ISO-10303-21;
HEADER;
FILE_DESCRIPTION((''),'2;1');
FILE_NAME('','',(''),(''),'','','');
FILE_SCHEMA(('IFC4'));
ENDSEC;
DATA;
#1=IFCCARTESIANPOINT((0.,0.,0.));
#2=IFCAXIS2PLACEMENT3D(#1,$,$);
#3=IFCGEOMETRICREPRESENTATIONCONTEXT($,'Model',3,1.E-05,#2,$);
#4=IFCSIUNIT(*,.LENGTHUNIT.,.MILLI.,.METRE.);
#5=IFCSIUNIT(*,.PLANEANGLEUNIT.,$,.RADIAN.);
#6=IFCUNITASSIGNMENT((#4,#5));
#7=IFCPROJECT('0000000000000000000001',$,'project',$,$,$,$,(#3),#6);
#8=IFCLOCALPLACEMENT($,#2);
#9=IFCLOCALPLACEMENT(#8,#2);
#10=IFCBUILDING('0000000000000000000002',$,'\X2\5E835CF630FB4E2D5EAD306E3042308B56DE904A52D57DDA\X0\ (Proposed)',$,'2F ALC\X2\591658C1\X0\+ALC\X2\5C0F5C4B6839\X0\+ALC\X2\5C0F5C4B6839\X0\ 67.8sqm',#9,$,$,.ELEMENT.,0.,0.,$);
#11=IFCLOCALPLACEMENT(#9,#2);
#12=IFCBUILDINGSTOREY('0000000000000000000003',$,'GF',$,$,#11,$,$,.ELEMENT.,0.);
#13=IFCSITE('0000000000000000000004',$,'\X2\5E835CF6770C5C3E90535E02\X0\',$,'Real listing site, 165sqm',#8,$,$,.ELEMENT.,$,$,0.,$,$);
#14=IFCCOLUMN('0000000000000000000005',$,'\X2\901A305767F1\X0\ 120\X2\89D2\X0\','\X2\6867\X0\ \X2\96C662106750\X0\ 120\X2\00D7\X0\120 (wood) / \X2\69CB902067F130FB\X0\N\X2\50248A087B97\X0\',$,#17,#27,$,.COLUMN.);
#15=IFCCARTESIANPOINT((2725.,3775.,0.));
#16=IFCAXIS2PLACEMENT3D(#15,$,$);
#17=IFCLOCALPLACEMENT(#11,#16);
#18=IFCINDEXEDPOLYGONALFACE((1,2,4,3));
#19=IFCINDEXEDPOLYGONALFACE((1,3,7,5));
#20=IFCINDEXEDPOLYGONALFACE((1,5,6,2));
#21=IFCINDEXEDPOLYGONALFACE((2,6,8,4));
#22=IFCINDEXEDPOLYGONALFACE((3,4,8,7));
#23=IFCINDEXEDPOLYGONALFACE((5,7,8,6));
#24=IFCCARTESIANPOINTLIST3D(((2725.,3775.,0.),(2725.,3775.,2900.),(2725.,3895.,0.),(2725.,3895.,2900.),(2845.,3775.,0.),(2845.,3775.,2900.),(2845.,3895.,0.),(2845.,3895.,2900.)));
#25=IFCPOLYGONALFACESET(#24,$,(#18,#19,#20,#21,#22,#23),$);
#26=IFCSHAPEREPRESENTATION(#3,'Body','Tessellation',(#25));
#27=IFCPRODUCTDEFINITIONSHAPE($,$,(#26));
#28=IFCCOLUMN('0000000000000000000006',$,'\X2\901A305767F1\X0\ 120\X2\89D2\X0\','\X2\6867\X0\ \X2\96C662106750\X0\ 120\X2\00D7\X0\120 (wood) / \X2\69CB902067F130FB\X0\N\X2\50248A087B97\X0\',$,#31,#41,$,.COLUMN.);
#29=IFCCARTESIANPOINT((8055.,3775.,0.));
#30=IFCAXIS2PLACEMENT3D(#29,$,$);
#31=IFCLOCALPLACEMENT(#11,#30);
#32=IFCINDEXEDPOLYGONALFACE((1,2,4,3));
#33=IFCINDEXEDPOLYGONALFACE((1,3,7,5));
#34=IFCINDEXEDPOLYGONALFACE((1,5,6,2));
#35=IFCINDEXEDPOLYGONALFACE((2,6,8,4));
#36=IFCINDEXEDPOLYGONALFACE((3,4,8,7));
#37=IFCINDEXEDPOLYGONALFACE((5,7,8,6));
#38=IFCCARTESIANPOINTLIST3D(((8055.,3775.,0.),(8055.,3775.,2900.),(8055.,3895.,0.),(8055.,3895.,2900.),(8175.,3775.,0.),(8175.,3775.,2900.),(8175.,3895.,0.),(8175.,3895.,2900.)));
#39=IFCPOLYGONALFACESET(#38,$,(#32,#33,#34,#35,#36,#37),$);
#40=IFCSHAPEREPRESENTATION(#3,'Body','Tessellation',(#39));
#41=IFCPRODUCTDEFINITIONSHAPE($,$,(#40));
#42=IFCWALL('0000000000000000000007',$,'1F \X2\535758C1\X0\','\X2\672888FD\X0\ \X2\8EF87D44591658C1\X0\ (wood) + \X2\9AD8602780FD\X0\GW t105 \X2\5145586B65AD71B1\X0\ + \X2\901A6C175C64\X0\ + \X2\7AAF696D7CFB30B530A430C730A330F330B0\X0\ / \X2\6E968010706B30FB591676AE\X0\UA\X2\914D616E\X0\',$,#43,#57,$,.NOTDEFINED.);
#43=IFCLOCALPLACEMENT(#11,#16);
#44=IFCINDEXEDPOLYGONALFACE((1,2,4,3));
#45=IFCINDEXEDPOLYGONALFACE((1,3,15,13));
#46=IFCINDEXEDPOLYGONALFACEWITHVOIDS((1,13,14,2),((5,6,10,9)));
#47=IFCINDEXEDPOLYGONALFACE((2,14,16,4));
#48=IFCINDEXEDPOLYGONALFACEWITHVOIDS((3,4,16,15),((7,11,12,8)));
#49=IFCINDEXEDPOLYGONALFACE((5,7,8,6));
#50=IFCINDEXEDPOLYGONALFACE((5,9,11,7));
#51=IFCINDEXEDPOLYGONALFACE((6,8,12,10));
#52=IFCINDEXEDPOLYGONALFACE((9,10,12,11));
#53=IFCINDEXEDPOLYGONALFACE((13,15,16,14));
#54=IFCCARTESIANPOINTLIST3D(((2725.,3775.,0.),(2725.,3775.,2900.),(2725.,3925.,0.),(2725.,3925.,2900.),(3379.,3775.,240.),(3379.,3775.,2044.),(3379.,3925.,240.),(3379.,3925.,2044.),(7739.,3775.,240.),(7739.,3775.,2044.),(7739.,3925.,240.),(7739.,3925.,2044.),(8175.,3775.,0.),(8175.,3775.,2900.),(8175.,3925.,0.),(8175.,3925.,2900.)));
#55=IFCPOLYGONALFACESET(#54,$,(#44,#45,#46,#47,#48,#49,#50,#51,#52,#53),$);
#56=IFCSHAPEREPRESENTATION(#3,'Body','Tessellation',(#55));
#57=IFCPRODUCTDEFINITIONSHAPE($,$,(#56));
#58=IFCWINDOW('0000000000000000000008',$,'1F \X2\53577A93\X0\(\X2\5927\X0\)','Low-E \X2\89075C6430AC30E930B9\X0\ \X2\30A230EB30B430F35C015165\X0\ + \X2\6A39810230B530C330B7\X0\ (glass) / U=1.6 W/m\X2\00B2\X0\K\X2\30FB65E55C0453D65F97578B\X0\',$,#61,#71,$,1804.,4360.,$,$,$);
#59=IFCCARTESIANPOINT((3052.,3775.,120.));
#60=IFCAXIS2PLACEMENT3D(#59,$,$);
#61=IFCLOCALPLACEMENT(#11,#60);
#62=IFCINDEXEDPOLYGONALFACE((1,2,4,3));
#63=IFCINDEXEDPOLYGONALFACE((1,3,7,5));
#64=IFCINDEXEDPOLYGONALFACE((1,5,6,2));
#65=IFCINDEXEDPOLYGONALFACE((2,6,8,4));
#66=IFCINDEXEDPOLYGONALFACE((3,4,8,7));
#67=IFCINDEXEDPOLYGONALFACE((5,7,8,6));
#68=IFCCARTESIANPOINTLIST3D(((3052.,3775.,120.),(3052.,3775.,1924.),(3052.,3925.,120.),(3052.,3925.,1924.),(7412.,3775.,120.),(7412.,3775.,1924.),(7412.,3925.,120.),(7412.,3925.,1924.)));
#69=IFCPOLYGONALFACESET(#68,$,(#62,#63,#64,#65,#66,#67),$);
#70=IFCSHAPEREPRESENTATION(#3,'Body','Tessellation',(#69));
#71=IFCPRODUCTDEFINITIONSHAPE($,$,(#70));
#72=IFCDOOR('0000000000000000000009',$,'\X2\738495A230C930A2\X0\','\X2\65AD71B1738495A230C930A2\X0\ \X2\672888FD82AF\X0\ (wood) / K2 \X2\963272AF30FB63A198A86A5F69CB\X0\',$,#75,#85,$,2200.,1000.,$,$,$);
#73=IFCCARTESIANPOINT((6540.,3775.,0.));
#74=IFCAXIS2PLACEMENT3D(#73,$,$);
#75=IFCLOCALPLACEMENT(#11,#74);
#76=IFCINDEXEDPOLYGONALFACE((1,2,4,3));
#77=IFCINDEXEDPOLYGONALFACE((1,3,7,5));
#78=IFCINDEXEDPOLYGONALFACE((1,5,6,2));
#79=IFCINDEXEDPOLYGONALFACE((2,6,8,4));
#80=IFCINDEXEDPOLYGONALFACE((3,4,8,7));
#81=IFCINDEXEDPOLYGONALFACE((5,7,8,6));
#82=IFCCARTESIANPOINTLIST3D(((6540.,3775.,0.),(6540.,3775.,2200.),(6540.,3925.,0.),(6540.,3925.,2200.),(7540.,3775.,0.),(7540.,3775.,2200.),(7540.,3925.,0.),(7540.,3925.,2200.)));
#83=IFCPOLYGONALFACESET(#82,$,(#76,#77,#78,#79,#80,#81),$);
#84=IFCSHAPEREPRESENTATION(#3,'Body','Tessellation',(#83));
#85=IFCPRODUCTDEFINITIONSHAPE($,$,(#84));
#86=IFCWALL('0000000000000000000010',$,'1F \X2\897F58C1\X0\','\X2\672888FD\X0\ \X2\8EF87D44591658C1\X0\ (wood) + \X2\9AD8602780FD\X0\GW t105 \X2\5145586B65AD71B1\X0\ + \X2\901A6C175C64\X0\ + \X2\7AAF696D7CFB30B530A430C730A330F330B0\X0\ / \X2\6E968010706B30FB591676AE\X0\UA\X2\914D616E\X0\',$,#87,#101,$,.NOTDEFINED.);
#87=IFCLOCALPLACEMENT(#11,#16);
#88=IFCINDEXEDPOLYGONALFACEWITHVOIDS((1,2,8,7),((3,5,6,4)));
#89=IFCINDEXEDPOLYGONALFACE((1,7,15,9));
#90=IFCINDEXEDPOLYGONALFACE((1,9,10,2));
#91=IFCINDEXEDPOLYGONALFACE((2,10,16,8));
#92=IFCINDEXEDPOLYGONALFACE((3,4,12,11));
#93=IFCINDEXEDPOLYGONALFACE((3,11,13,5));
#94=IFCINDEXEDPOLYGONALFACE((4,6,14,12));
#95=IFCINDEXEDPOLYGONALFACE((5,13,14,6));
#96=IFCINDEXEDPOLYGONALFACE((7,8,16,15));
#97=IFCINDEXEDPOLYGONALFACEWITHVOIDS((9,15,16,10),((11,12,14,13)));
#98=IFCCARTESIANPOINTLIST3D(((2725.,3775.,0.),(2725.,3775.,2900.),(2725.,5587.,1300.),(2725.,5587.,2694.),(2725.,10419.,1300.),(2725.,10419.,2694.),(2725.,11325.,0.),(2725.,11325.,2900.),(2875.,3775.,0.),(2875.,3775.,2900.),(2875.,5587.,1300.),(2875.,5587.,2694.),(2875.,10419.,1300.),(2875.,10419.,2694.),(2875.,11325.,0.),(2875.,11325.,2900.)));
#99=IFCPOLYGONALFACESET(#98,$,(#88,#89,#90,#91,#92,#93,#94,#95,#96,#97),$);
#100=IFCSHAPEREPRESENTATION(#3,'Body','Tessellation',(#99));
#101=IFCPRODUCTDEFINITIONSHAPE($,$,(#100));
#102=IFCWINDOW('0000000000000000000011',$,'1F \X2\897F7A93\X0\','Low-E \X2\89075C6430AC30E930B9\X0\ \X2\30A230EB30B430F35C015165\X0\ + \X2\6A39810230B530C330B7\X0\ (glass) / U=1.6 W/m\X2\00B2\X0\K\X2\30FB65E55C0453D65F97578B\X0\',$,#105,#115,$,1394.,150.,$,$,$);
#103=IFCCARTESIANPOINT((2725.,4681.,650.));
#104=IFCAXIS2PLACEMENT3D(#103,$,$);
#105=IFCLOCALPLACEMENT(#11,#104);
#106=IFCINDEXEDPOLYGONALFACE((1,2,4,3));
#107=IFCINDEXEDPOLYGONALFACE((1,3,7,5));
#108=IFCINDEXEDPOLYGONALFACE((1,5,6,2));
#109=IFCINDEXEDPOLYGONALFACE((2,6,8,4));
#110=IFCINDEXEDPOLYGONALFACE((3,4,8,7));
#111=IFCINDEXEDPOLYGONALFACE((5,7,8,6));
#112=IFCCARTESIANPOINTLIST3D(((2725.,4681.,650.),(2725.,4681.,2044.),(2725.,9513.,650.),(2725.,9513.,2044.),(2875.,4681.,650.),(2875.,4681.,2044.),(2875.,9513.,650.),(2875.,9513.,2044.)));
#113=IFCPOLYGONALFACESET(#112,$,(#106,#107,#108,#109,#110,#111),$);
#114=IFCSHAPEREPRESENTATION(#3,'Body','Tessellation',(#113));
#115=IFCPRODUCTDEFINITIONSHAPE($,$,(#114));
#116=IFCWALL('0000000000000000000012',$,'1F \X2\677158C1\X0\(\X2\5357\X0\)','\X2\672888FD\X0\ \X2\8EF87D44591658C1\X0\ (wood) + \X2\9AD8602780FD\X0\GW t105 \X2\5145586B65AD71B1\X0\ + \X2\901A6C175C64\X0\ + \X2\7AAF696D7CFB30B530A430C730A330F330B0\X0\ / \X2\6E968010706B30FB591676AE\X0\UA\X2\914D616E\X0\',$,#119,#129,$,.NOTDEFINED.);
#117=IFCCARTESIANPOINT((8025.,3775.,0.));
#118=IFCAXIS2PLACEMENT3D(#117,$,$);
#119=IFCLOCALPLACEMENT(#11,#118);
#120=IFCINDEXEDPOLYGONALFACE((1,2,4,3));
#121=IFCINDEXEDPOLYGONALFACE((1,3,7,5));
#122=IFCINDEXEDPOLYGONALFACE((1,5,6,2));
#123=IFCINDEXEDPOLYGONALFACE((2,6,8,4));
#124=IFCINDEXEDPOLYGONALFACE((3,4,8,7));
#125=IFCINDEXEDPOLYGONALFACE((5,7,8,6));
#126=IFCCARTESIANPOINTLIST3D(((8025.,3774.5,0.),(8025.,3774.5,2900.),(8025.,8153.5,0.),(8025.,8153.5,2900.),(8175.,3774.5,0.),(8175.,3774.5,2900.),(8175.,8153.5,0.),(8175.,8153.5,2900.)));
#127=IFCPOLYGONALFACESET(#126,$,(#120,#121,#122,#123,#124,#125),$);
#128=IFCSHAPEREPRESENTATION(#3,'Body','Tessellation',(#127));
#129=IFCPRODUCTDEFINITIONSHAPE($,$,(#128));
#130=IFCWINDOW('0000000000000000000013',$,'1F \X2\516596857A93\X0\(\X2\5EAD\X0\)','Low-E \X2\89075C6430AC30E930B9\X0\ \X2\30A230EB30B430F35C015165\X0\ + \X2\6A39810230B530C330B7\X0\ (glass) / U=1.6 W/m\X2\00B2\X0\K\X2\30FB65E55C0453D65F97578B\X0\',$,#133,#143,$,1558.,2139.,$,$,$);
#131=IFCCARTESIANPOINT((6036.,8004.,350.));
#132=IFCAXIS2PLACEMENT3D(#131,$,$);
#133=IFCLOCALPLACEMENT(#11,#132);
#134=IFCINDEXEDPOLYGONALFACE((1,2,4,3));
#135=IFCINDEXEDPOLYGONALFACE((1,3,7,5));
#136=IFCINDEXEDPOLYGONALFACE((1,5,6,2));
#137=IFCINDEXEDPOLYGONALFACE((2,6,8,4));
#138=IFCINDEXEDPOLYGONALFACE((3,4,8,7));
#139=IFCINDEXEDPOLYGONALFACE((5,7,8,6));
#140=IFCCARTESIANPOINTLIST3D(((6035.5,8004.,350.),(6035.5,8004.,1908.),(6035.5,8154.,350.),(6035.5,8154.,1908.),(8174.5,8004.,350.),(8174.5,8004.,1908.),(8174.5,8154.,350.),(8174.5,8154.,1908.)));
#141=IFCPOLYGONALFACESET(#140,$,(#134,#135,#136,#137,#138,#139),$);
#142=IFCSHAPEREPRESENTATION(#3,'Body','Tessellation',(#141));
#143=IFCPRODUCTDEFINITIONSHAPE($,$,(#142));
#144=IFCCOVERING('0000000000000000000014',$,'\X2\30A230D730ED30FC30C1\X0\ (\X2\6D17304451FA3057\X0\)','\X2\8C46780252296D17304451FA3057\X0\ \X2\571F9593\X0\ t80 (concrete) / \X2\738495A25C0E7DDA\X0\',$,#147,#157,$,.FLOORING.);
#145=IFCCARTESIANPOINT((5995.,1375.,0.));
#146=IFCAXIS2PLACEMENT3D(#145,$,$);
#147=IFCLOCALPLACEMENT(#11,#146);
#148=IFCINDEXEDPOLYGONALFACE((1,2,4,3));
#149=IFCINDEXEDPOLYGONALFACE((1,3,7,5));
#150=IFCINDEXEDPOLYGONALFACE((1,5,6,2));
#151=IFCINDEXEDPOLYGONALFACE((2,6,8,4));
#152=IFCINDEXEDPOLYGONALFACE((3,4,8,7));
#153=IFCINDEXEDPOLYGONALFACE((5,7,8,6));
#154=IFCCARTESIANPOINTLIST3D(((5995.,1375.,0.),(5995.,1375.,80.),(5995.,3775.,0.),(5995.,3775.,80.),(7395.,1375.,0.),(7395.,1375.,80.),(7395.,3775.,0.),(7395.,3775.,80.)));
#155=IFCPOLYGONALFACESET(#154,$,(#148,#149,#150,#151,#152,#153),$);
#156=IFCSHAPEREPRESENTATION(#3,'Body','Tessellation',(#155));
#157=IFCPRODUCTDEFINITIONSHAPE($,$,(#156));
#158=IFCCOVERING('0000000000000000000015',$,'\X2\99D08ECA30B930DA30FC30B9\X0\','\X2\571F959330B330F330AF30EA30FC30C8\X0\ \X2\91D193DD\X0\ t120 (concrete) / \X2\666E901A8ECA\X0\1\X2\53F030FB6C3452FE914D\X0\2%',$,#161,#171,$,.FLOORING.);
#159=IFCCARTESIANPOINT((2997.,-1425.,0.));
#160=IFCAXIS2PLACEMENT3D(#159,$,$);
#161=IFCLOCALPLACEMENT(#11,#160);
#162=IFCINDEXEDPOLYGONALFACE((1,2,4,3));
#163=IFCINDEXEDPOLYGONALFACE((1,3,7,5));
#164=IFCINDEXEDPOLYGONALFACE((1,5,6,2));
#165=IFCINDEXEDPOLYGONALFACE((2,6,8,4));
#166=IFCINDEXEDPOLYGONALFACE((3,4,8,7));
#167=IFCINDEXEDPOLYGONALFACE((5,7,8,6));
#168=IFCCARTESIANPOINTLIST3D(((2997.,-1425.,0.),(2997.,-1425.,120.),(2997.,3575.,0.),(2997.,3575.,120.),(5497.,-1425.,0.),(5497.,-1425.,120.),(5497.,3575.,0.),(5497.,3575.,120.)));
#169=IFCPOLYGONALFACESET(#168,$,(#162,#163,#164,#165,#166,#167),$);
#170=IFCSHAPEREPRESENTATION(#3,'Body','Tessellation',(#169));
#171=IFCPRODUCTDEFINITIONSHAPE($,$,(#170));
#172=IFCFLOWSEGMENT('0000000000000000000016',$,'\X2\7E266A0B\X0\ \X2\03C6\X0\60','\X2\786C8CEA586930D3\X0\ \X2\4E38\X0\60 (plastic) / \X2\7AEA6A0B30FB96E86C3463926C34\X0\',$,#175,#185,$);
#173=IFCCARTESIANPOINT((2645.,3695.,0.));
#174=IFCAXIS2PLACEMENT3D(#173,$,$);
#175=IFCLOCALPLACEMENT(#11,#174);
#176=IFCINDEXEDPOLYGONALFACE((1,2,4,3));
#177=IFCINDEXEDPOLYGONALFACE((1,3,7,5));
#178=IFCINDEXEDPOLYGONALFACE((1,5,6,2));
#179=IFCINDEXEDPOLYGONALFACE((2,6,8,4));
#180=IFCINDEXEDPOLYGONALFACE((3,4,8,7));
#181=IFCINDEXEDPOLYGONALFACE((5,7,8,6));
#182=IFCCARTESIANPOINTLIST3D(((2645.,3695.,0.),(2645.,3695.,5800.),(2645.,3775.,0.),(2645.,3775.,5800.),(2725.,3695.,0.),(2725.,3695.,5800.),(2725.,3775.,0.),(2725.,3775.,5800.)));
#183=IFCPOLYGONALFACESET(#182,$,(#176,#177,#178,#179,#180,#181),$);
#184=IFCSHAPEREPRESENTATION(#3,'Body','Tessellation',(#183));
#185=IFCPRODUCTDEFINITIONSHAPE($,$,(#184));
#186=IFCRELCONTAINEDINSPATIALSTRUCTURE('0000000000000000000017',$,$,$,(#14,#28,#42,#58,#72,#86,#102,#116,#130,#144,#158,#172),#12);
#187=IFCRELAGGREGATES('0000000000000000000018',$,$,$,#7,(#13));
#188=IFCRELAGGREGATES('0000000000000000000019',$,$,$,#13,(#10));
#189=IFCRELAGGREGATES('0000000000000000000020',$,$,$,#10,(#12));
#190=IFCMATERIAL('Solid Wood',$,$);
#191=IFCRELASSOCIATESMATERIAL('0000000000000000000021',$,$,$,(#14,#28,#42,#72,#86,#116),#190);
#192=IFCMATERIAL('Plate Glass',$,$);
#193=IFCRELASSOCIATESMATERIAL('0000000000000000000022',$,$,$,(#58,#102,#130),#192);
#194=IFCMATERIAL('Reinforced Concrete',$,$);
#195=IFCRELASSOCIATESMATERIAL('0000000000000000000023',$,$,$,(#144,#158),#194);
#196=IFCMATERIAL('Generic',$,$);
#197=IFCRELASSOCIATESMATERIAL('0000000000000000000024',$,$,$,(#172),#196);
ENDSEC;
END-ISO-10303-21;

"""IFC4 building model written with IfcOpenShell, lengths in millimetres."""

from ifc_helpers import new_model, si_unit, frame, frame_2d, origin, place, context, project, spatial, rectangle, extrude, material, element, fill, save


model = new_model("IFC4")

# Units and contexts
model_context = context("Model", 3, precision=1e-05, world=origin())
ifc_project = project(units=[si_unit("LENGTHUNIT", "METRE", prefix="MILLI"), si_unit("PLANEANGLEUNIT", "RADIAN")], contexts=[model_context])

# Site, building, storey
site_placement = place(None, origin())
site = spatial("IfcSite", under=ifc_project, at=site_placement, Name="広島県尾道市", ObjectType="Real listing site, 165sqm", CompositionType="ELEMENT", RefElevation=0.0)
building_placement = place(site_placement, origin())
building = spatial("IfcBuilding", under=site, at=building_placement, Name="広島・中庭のある回遊動線 (Proposed)", ObjectType="2F ALC外壁+ALC小屋根+ALC小屋根 67.8sqm", CompositionType="ELEMENT", ElevationOfRefHeight=0.0, ElevationOfTerrain=0.0)
storey_placement = place(building_placement, origin())
storey = spatial("IfcBuildingStorey", under=building, at=storey_placement, Name="GF", CompositionType="ELEMENT", Elevation=0.0)

# Columns
ifc_material_1 = material(Name="Solid Wood")
column_1_placement = place(storey_placement, frame((2725.0, 3775.0, 0.0)))
element("IfcColumn", 1, at=column_1_placement, inside=storey, material=ifc_material_1, Name="通し柱 120角", Description="桧 集成材 120×120 (wood) / 構造柱・N値計算", PredefinedType="COLUMN", context=model_context, shape_type="SweptSolid", body=[
    extrude(rectangle(XDim=120.0, YDim=120.0, at=frame_2d((60.0, 60.0))), frame((2725.0, 3775.0, 0.0)), (0.0, 0.0, 1.0), 2900.0),
])
column_2_placement = place(storey_placement, frame((8055.0, 3775.0, 0.0)))
element("IfcColumn", 2, at=column_2_placement, inside=storey, material=ifc_material_1, Name="通し柱 120角", Description="桧 集成材 120×120 (wood) / 構造柱・N値計算", PredefinedType="COLUMN", context=model_context, shape_type="SweptSolid", body=[
    extrude(rectangle(XDim=120.0, YDim=120.0, at=frame_2d((60.0, 60.0))), frame((8055.0, 3775.0, 0.0)), (0.0, 0.0, 1.0), 2900.0),
])

# Shared definitions
ifc_material_2 = material(Name="Reinforced Concrete")

# Wall, openings, window, door
wall_1_placement = place(storey_placement, frame((2725.0, 3775.0, 0.0)))
wall_1 = element("IfcWall", 3, at=wall_1_placement, inside=storey, material=ifc_material_1, Name="1F 南壁", Description="木製 軸組外壁 (wood) + 高性能GW t105 充填断熱 + 通気層 + 窯業系サイディング / 準耐火・外皮UA配慮", PredefinedType="NOTDEFINED", context=model_context, shape_type="SweptSolid", body=[
    extrude(rectangle(XDim=5450.0, YDim=150.0, at=frame_2d((2725.0, 75.0))), frame((2725.0, 3775.0, 0.0)), (0.0, 0.0, 1.0), 2900.0),
])
opening_1_placement = place(storey_placement, frame((3052.0, 3775.0, 120.0)))
opening_1 = element("IfcOpeningElement", 4, at=opening_1_placement, cuts=wall_1, PredefinedType="NOTDEFINED", context=model_context, shape_type="SweptSolid", body=[
    extrude(rectangle(XDim=4360.0, YDim=150.0, at=frame_2d((2180.0, 75.0))), frame((3052.0, 3775.0, 120.0)), (0.0, 0.0, 1.0), 1804.0),
])
opening_2_placement = place(storey_placement, frame((6540.0, 3775.0, 0.0)))
opening_2 = element("IfcOpeningElement", 5, at=opening_2_placement, cuts=wall_1, PredefinedType="NOTDEFINED", context=model_context, shape_type="SweptSolid", body=[
    extrude(rectangle(XDim=1000.0, YDim=150.0, at=frame_2d((500.0, 75.0))), frame((6540.0, 3775.0, 0.0)), (0.0, 0.0, 1.0), 2200.0),
])
ifc_material_3 = material(Name="Plate Glass")
window_1_placement = place(storey_placement, frame((3052.0, 3775.0, 120.0)))
window_1 = element("IfcWindow", 6, at=window_1_placement, inside=storey, material=ifc_material_3, Name="1F 南窓(大)", Description="Low-E 複層ガラス アルゴン封入 + 樹脂サッシ (glass) / U=1.6 W/m²K・日射取得型", OverallHeight=1804.0, OverallWidth=4360.0, context=model_context, shape_type="SweptSolid", body=[
    extrude(rectangle(XDim=4360.0, YDim=150.0, at=frame_2d((2180.0, 75.0))), frame((3052.0, 3775.0, 120.0)), (0.0, 0.0, 1.0), 1804.0),
])
fill(opening_1, window_1)
door_1_placement = place(storey_placement, frame((6540.0, 3775.0, 0.0)))
door_1 = element("IfcDoor", 7, at=door_1_placement, inside=storey, material=ifc_material_1, Name="玄関ドア", Description="断熱玄関ドア 木製芯 (wood) / K2 防犯・採風機構", OverallHeight=2200.0, OverallWidth=1000.0, context=model_context, shape_type="SweptSolid", body=[
    extrude(rectangle(XDim=1000.0, YDim=150.0, at=frame_2d((500.0, 75.0))), frame((6540.0, 3775.0, 0.0)), (0.0, 0.0, 1.0), 2200.0),
])
fill(opening_2, door_1)

# Walls, openings, windows
wall_2_placement = place(storey_placement, frame((2725.0, 3775.0, 0.0)))
wall_2 = element("IfcWall", 8, at=wall_2_placement, inside=storey, material=ifc_material_1, Name="1F 西壁", Description="木製 軸組外壁 (wood) + 高性能GW t105 充填断熱 + 通気層 + 窯業系サイディング / 準耐火・外皮UA配慮", PredefinedType="NOTDEFINED", context=model_context, shape_type="SweptSolid", body=[
    extrude(rectangle(XDim=150.0, YDim=7550.0, at=frame_2d((75.0, 3775.0))), frame((2725.0, 3775.0, 0.0)), (0.0, 0.0, 1.0), 2900.0),
])
opening_3_placement = place(storey_placement, frame((2725.0, 4681.0, 650.0)))
opening_3 = element("IfcOpeningElement", 9, at=opening_3_placement, cuts=wall_2, PredefinedType="NOTDEFINED", context=model_context, shape_type="SweptSolid", body=[
    extrude(rectangle(XDim=150.0, YDim=4832.0, at=frame_2d((75.0, 2416.0))), frame((2725.0, 4681.0, 650.0)), (0.0, 0.0, 1.0), 1394.0),
])
window_2_placement = place(storey_placement, frame((2725.0, 4681.0, 650.0)))
window_2 = element("IfcWindow", 10, at=window_2_placement, inside=storey, material=ifc_material_3, Name="1F 西窓", Description="Low-E 複層ガラス アルゴン封入 + 樹脂サッシ (glass) / U=1.6 W/m²K・日射取得型", OverallHeight=1394.0, OverallWidth=150.0, context=model_context, shape_type="SweptSolid", body=[
    extrude(rectangle(XDim=150.0, YDim=4832.0, at=frame_2d((75.0, 2416.0))), frame((2725.0, 4681.0, 650.0)), (0.0, 0.0, 1.0), 1394.0),
])
fill(opening_3, window_2)
wall_3_placement = place(storey_placement, frame((8025.0, 3775.0, 0.0)))
wall_3 = element("IfcWall", 11, at=wall_3_placement, inside=storey, material=ifc_material_1, Name="1F 東壁(南)", Description="木製 軸組外壁 (wood) + 高性能GW t105 充填断熱 + 通気層 + 窯業系サイディング / 準耐火・外皮UA配慮", PredefinedType="NOTDEFINED", context=model_context, shape_type="SweptSolid", body=[
    extrude(rectangle(XDim=150.0, YDim=4379.0, at=frame_2d((75.0, 2189.0))), frame((8025.0, 3775.0, 0.0)), (0.0, 0.0, 1.0), 2900.0),
])
opening_4_placement = place(storey_placement, frame((6036.0, 8004.0, 350.0)))
opening_4 = element("IfcOpeningElement", 12, at=opening_4_placement, cuts=wall_3, PredefinedType="NOTDEFINED", context=model_context, shape_type="SweptSolid", body=[
    extrude(rectangle(XDim=2139.0, YDim=150.0, at=frame_2d((1069.0, 75.0))), frame((6036.0, 8004.0, 350.0)), (0.0, 0.0, 1.0), 1558.0),
])
window_3_placement = place(storey_placement, frame((6036.0, 8004.0, 350.0)))
window_3 = element("IfcWindow", 13, at=window_3_placement, inside=storey, material=ifc_material_3, Name="1F 入隅窓(庭)", Description="Low-E 複層ガラス アルゴン封入 + 樹脂サッシ (glass) / U=1.6 W/m²K・日射取得型", OverallHeight=1558.0, OverallWidth=2139.0, context=model_context, shape_type="SweptSolid", body=[
    extrude(rectangle(XDim=2139.0, YDim=150.0, at=frame_2d((1069.0, 75.0))), frame((6036.0, 8004.0, 350.0)), (0.0, 0.0, 1.0), 1558.0),
])
fill(opening_4, window_3)

# Coverings
covering_1_placement = place(storey_placement, frame((5995.0, 1375.0, 0.0)))
element("IfcCovering", 14, at=covering_1_placement, inside=storey, material=ifc_material_2, Name="アプローチ (洗い出し)", Description="豆砂利洗い出し 土間 t80 (concrete) / 玄関導線", PredefinedType="FLOORING", context=model_context, shape_type="SweptSolid", body=[
    extrude(rectangle(XDim=1400.0, YDim=2400.0, at=frame_2d((700.0, 1200.0))), frame((5995.0, 1375.0, 0.0)), (0.0, 0.0, 1.0), 80.0),
])
covering_2_placement = place(storey_placement, frame((2997.0, -1425.0, 0.0)))
element("IfcCovering", 15, at=covering_2_placement, inside=storey, material=ifc_material_2, Name="駐車スペース", Description="土間コンクリート 金鏝 t120 (concrete) / 普通車1台・水勾配2%", PredefinedType="FLOORING", context=model_context, shape_type="SweptSolid", body=[
    extrude(rectangle(XDim=2500.0, YDim=5000.0, at=frame_2d((1250.0, 2500.0))), frame((2997.0, -1425.0, 0.0)), (0.0, 0.0, 1.0), 120.0),
])

# Flow segment
ifc_material_4 = material(Name="Generic")
flow_segment_1_placement = place(storey_placement, frame((2645.0, 3695.0, 0.0)))
element("IfcFlowSegment", 16, at=flow_segment_1_placement, inside=storey, material=ifc_material_4, Name="縦樋 φ60", Description="硬質塩ビ 丸60 (plastic) / 竪樋・雨水排水", context=model_context, shape_type="SweptSolid", body=[
    extrude(rectangle(XDim=80.0, YDim=80.0, at=frame_2d((40.0, 40.0))), frame((2645.0, 3695.0, 0.0)), (0.0, 0.0, 1.0), 5800.0),
])

save(model, "model.ifc")
